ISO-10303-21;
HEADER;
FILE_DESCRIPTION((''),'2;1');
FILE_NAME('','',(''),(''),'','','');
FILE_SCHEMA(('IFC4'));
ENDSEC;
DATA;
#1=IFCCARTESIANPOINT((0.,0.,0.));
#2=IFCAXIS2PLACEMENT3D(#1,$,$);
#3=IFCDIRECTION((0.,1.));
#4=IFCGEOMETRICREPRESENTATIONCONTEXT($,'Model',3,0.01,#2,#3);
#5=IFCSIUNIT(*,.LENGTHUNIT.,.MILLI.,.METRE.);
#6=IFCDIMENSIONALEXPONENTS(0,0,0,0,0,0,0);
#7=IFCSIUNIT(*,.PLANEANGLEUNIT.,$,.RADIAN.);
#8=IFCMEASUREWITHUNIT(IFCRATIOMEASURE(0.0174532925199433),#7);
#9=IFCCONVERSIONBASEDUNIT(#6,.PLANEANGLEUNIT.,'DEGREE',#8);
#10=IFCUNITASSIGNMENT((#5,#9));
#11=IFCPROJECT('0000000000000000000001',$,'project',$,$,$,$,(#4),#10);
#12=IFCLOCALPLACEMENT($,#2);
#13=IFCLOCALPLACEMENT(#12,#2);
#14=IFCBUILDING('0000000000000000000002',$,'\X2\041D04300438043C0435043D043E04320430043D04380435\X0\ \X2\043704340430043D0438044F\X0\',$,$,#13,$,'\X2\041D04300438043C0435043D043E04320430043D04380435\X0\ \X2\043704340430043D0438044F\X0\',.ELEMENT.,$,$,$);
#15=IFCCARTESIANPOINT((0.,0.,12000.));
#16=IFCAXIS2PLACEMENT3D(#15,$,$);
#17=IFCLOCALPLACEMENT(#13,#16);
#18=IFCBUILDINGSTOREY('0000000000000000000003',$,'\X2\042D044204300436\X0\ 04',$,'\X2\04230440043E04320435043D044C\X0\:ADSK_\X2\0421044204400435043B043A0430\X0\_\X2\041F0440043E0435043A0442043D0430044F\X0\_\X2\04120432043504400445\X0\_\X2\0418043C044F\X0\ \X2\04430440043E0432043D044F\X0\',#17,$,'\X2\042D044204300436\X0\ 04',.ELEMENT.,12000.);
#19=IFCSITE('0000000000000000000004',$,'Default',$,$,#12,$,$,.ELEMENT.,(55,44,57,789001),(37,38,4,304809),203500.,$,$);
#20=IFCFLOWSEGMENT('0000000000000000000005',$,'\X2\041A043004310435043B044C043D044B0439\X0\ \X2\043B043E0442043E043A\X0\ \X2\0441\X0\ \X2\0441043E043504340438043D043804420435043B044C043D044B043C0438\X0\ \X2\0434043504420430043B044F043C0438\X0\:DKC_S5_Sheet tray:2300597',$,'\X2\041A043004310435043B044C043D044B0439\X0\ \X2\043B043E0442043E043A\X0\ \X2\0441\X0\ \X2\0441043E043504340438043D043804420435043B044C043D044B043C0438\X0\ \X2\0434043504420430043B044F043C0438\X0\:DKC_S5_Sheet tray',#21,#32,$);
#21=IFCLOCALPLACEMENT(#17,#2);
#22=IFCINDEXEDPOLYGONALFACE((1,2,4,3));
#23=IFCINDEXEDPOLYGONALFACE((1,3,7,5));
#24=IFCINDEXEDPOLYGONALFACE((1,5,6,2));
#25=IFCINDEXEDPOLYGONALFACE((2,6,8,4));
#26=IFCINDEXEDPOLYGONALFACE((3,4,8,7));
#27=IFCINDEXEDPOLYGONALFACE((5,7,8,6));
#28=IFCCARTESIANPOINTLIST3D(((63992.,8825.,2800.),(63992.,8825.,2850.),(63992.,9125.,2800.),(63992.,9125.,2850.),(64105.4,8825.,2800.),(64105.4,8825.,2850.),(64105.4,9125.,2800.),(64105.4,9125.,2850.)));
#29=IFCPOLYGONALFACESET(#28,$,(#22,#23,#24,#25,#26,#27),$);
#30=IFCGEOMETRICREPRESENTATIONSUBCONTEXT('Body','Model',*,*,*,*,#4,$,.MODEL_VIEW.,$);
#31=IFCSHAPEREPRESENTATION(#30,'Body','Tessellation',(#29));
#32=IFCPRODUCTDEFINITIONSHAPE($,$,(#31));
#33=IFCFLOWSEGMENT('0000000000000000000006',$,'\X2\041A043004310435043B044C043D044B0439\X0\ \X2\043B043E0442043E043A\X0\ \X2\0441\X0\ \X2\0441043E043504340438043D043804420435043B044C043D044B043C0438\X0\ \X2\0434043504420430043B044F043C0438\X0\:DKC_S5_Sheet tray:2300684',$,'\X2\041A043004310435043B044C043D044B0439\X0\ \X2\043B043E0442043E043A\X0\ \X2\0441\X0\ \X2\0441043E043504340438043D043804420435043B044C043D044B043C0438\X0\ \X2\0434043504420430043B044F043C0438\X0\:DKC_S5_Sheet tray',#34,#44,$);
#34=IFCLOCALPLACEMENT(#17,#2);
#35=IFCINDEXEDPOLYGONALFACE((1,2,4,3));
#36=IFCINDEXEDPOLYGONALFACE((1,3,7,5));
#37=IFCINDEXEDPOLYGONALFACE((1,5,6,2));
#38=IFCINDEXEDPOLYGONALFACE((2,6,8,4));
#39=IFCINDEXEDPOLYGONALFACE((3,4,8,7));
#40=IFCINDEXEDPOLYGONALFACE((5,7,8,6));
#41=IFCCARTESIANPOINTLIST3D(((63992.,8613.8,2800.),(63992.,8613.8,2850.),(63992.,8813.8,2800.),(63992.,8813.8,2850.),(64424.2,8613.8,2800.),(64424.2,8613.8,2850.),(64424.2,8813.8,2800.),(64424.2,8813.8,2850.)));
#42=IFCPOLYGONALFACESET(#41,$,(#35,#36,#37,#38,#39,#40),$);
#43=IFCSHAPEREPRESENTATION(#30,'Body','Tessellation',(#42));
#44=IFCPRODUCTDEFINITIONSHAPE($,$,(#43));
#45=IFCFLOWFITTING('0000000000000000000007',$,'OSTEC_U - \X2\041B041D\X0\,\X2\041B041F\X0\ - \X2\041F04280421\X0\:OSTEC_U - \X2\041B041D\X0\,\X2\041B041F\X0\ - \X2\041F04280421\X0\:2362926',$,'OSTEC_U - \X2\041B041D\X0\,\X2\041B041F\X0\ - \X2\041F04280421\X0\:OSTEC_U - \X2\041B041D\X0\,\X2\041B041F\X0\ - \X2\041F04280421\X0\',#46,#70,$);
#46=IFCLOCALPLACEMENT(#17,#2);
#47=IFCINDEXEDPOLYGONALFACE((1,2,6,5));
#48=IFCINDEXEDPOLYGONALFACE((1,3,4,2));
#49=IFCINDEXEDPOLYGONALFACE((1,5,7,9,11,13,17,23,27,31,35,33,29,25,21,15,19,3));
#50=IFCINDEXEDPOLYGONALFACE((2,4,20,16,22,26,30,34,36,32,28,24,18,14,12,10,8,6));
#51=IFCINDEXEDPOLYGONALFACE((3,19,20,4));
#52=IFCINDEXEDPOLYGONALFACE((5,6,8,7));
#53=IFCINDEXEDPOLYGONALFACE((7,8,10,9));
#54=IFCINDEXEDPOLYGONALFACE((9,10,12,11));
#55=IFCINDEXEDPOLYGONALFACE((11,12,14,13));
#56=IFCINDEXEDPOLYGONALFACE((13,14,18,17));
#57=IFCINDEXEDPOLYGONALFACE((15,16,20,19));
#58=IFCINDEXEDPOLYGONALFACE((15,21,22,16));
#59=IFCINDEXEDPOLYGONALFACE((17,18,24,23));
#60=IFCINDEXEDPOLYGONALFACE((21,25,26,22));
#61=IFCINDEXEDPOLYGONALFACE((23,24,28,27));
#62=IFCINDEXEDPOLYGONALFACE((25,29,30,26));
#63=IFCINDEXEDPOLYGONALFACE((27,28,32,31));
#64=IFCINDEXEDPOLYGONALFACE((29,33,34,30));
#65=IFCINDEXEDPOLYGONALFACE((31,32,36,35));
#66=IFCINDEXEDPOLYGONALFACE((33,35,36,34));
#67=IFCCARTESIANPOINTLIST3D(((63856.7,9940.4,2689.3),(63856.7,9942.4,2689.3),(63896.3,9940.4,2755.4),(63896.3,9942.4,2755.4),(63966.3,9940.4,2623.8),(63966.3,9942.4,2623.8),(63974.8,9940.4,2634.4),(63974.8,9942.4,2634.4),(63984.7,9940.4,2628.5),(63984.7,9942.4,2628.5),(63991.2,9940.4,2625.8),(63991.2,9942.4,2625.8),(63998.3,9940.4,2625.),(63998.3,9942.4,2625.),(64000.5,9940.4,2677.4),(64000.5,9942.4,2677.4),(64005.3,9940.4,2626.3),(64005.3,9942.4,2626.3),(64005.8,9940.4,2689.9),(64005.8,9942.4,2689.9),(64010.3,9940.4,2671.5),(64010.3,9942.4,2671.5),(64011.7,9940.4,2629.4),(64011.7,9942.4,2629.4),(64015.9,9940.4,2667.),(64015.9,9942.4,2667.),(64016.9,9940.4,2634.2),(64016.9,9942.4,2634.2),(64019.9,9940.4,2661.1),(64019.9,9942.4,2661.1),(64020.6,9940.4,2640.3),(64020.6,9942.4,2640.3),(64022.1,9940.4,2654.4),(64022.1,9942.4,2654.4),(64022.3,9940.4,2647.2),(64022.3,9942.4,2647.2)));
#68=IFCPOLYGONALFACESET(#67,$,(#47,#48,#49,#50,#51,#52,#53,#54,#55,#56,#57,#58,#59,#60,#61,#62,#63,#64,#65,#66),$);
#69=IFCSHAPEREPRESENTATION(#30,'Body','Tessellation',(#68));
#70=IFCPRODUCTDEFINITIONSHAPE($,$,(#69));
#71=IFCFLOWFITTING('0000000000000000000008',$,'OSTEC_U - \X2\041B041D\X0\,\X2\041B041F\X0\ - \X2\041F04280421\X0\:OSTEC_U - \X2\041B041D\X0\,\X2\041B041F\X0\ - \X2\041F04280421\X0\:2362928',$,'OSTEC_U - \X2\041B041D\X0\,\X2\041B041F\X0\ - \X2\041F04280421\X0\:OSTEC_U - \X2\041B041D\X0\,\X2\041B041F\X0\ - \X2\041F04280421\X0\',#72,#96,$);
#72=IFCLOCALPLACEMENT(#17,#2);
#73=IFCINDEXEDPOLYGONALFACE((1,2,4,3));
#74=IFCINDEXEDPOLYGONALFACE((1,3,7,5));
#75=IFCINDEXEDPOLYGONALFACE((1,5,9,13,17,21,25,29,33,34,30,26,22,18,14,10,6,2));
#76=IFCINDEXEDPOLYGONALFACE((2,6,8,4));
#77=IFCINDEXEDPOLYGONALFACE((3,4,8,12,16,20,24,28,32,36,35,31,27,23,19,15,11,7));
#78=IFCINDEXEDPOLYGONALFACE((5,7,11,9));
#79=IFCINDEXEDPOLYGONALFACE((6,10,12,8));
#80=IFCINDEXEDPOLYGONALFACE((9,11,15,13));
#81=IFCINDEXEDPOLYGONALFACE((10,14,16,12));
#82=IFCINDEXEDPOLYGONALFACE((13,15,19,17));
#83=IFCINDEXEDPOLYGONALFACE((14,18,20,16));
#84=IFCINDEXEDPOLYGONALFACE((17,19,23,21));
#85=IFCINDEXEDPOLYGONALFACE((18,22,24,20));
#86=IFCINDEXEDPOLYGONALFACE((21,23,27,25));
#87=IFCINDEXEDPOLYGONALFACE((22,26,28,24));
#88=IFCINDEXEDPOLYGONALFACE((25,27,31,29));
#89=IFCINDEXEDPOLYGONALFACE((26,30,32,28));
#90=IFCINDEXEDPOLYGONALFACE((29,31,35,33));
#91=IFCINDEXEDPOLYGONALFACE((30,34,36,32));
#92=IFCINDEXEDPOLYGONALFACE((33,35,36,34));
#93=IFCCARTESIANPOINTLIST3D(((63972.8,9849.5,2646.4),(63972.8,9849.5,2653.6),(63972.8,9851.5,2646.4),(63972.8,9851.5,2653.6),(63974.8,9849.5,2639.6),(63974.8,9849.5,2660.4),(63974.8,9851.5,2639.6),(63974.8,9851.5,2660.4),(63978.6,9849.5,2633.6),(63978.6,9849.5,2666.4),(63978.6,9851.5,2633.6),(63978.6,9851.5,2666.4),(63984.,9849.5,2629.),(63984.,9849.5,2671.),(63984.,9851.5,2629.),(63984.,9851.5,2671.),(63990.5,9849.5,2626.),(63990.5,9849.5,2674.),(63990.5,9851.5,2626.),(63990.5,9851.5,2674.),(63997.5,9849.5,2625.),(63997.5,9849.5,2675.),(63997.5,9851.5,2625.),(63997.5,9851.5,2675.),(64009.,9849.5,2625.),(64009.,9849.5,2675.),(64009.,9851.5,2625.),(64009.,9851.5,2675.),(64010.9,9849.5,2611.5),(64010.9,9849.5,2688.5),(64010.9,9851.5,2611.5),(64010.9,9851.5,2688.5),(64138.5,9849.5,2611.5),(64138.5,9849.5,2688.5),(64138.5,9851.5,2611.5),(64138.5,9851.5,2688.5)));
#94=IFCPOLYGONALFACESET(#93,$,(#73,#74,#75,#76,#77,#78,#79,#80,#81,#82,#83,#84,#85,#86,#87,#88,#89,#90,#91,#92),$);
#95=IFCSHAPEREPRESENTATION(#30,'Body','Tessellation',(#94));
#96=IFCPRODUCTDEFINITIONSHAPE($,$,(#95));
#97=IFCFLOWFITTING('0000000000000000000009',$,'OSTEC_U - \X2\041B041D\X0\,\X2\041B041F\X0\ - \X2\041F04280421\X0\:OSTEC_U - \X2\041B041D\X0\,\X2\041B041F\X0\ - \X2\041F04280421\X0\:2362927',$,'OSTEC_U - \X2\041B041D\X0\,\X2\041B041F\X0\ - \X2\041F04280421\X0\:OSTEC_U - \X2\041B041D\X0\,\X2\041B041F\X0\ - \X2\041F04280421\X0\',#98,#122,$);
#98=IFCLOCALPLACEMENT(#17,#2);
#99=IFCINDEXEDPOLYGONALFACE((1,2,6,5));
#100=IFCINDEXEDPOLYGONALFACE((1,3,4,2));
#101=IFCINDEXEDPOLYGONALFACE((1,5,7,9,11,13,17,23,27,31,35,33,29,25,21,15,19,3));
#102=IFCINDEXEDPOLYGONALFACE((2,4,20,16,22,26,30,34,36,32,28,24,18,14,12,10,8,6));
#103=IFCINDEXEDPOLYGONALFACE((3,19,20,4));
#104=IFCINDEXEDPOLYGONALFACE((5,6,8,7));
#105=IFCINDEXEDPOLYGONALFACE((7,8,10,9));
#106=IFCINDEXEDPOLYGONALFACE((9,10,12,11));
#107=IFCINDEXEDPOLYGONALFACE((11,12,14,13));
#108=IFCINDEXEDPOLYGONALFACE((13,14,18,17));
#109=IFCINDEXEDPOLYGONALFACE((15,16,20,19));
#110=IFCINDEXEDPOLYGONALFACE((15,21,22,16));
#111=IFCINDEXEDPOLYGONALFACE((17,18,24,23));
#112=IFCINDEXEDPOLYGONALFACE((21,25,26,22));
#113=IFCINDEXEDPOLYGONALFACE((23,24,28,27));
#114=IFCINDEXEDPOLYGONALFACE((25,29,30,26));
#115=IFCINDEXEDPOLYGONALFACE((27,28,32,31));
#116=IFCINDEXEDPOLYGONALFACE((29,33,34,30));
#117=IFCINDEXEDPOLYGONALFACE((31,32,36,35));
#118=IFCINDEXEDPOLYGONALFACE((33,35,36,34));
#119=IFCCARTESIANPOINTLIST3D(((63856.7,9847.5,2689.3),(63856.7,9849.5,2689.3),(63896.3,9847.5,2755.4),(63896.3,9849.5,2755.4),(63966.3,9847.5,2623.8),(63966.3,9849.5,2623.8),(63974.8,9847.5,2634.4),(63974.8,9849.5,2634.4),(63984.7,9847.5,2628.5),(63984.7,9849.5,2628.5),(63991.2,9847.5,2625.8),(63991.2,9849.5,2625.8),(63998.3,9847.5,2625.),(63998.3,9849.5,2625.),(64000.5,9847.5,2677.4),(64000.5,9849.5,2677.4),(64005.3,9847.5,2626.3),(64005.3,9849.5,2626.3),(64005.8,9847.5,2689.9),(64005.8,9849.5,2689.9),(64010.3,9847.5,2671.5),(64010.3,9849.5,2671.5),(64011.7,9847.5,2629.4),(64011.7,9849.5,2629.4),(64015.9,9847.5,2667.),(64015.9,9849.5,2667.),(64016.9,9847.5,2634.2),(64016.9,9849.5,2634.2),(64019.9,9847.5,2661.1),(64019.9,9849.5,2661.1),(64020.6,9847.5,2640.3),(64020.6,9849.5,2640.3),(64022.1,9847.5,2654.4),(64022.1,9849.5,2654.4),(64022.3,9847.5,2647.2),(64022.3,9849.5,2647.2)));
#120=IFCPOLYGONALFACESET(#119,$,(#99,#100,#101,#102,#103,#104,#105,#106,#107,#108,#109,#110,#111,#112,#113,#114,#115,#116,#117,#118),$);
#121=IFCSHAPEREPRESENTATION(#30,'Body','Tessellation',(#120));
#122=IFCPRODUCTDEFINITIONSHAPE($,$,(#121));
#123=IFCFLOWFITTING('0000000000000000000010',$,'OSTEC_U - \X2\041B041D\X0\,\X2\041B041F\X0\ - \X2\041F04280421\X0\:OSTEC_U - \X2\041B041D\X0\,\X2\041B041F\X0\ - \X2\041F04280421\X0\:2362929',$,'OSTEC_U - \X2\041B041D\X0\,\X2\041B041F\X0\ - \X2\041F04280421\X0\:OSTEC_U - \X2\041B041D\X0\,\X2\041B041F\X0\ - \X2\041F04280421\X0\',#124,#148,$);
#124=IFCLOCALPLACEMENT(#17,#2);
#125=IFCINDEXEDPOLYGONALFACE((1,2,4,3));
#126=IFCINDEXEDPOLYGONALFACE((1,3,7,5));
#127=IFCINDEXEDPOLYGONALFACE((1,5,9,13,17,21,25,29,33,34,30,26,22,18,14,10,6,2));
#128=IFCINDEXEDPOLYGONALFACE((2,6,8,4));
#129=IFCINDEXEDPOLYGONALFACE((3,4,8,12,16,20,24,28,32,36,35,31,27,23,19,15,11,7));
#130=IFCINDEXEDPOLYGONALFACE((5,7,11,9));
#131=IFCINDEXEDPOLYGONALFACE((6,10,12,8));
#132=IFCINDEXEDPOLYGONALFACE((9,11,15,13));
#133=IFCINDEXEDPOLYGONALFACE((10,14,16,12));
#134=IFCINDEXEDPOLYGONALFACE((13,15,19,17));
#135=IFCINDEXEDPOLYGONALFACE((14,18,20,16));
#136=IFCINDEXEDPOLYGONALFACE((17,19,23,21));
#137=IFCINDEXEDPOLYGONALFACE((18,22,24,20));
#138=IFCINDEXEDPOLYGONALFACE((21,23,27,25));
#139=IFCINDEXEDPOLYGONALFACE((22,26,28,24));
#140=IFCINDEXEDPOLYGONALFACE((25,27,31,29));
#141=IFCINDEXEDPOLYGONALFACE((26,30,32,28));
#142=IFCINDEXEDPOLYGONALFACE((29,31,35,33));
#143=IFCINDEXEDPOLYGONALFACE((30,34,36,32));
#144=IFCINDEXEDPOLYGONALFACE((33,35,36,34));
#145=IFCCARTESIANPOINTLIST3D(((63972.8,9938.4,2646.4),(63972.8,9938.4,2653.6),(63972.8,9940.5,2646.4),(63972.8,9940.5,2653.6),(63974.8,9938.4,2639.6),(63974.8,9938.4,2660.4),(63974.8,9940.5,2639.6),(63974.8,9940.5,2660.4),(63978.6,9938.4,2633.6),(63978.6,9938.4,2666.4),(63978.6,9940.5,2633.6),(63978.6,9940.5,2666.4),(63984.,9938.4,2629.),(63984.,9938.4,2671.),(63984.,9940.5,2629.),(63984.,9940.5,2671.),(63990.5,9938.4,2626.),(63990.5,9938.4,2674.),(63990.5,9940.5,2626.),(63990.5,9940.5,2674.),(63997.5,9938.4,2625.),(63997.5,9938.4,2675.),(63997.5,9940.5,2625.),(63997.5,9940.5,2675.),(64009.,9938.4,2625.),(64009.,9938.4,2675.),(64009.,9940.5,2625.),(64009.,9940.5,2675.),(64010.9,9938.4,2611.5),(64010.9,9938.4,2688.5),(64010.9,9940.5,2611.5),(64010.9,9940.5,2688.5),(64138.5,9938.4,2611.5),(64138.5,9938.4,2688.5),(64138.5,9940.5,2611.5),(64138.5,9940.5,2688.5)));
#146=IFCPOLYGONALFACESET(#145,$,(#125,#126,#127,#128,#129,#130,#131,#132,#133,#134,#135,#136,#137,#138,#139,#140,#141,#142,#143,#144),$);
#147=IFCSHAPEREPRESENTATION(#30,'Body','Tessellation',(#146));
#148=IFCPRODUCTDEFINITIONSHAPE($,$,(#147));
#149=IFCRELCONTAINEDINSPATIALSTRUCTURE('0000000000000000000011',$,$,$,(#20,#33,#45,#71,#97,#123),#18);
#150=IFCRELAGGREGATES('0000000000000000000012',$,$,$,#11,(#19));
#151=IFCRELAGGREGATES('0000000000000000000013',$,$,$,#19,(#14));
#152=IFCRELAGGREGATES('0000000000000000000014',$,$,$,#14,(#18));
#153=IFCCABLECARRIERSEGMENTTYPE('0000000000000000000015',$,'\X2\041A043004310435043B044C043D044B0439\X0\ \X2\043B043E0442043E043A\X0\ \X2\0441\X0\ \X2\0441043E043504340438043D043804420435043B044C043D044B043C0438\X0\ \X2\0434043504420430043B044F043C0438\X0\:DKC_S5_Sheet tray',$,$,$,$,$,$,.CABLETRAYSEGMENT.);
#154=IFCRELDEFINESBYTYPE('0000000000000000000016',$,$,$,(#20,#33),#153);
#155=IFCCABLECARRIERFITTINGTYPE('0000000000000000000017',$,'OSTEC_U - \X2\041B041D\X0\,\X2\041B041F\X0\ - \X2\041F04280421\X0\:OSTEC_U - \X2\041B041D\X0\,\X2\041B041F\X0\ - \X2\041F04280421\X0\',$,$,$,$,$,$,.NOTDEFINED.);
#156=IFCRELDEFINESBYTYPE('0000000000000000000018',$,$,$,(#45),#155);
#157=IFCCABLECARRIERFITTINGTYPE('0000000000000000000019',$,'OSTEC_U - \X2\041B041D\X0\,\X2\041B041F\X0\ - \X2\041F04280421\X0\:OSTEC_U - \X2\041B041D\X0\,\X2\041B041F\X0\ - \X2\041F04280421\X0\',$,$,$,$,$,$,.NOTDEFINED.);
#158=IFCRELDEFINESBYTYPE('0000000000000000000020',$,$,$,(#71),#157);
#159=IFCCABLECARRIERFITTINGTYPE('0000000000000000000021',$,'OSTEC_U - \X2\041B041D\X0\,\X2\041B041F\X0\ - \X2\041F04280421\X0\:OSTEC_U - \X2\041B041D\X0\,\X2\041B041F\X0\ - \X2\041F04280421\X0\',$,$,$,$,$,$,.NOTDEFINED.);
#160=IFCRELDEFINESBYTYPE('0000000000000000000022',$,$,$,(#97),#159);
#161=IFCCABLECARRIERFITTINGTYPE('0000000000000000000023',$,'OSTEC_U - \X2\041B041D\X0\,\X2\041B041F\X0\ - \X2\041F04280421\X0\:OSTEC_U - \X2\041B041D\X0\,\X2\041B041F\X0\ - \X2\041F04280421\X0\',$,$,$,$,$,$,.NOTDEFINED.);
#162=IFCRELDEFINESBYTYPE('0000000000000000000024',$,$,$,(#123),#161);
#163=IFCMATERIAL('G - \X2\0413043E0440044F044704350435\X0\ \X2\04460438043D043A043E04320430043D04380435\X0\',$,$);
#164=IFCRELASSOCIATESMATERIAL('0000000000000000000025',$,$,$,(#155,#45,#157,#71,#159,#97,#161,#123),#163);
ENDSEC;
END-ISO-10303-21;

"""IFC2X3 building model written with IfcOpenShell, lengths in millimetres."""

from ifc_helpers import new_model, entity, si_unit, converted_unit, direction, frame, frame_2d, origin, origin_2d_with_axis, place, context, subcontext, project, spatial, polyline, circle_curve, parameter, trimmed, segment, composite_curve, rectangle, outline, extrude, source, transform, mapped, material, type_object, type_shapes, element, save


model = new_model("IFC2X3")

# Units and contexts
model_context = context("Model", 3, precision=0.01, world=origin(), true_north=direction((0.0, 1.0)))
body_context = subcontext(model_context, "Body", "Model", "MODEL_VIEW")
ifc_project = project(units=[si_unit("LENGTHUNIT", "METRE", prefix="MILLI"), converted_unit("PLANEANGLEUNIT", "DEGREE", entity("IfcRatioMeasure", 0.0174532925199433), si_unit("PLANEANGLEUNIT", "RADIAN"), dimensions=[0, 0, 0, 0, 0, 0, 0])], contexts=[model_context])

# Site, building, storey
site_placement = place(None, origin())
site = spatial("IfcSite", under=ifc_project, at=site_placement, Name="Default", CompositionType="ELEMENT", RefLatitude=(55, 44, 57, 789001), RefLongitude=(37, 38, 4, 304809), RefElevation=203500.0)
building_placement = place(site_placement, origin())
building = spatial("IfcBuilding", under=site, at=building_placement, Name="Наименование здания", LongName="Наименование здания", CompositionType="ELEMENT")
storey_placement = place(building_placement, frame((0.0, 0.0, 12000.0)))
storey = spatial("IfcBuildingStorey", under=building, at=storey_placement, Name="Этаж 04", ObjectType="Уровень:ADSK_Стрелка_Проектная_Вверх_Имя уровня", LongName="Этаж 04", CompositionType="ELEMENT", Elevation=12000.0)

# Flow segments
cable_carrier_segment_type = type_object("IfcCableCarrierSegmentType", Name="Кабельный лоток с соединительными деталями:DKC_S5_Sheet tray", PredefinedType="CABLETRAYSEGMENT")
flow_segment_1_placement = place(storey_placement, frame((63992.0, 8825.0, 2800.0)))
element("IfcFlowSegment", 1, at=flow_segment_1_placement, inside=storey, type_object=cable_carrier_segment_type, Name="Кабельный лоток с соединительными деталями:DKC_S5_Sheet tray:2300597", ObjectType="Кабельный лоток с соединительными деталями:DKC_S5_Sheet tray", context=body_context, shape_type="SweptSolid", body=[
    extrude(rectangle(XDim=113.4, YDim=300.0, at=origin_2d_with_axis()), frame((56.7, 150.0, 0.0)), (0.0, 0.0, 1.0), 50.0),
])
flow_segment_2_placement = place(storey_placement, frame((63992.0, 8613.8, 2800.0)))
element("IfcFlowSegment", 2, at=flow_segment_2_placement, inside=storey, type_object=cable_carrier_segment_type, Name="Кабельный лоток с соединительными деталями:DKC_S5_Sheet tray:2300684", ObjectType="Кабельный лоток с соединительными деталями:DKC_S5_Sheet tray", context=body_context, shape_type="SweptSolid", body=[
    extrude(rectangle(XDim=432.2, YDim=200.0, at=origin_2d_with_axis()), frame((216.1, 100.0, 0.0)), (0.0, 0.0, 1.0), 50.0),
])

# Flow fittings
ifc_material = material(Name="G - Горячее цинкование")
cable_carrier_fitting_type_1 = type_object("IfcCableCarrierFittingType", Name="OSTEC_U - ЛН,ЛП - ПШС:OSTEC_U - ЛН,ЛП - ПШС", PredefinedType="NOTDEFINED", material=ifc_material)
shared_shape_1 = source(origin(), body_context, "Body", "SweptSolid", [
    extrude(outline(composite_curve([segment(trimmed(circle_curve(frame_2d((-41.5, 0.0), x_axis=(1.0, 0.0)), 25.0), [parameter(90.0)], [parameter(270.0)], True, "PARAMETER"), True, "CONTINUOUS"), segment(polyline([(-41.5, -25.0), (-30.0, -25.0)]), True, "CONTINUOUS"), segment(polyline([(-30.0, -25.0), (-28.1, -38.5)]), True, "CONTINUOUS"), segment(polyline([(-28.1, -38.5), (99.5, -38.5)]), True, "CONTINUOUS"), segment(polyline([(99.5, -38.5), (99.5, 38.5)]), True, "CONTINUOUS"), segment(polyline([(99.5, 38.5), (-28.1, 38.5)]), True, "CONTINUOUS"), segment(polyline([(-28.1, 38.5), (-30.0, 25.0)]), True, "CONTINUOUS"), segment(polyline([(-30.0, 25.0), (-41.5, 25.0)]), True, "CONTINUOUS")], self_intersect=False)), frame((41.5, 0.0, 0.0), z_axis=(0.0, 0.0, -1.0), x_axis=(1.0, 0.0, 0.0)), (0.0, 0.0, -1.0), 2.0),
])
type_shapes(cable_carrier_fitting_type_1, [shared_shape_1])
flow_fitting_1_placement = place(storey_placement, frame((63997.5, 9940.5, 2650.0), z_axis=(0.0, 1.0, 0.0), x_axis=(-0.858171, 0.0, 0.513364)))
element("IfcFlowFitting", 3, at=flow_fitting_1_placement, inside=storey, type_object=cable_carrier_fitting_type_1, material=ifc_material, Name="OSTEC_U - ЛН,ЛП - ПШС:OSTEC_U - ЛН,ЛП - ПШС:2362926", ObjectType="OSTEC_U - ЛН,ЛП - ПШС:OSTEC_U - ЛН,ЛП - ПШС", context=body_context, shape_type="MappedRepresentation", body=[
    mapped(shared_shape_1, transform((0.0, 0.0, 0.0), scale=1.0)),
])
cable_carrier_fitting_type_2 = type_object("IfcCableCarrierFittingType", Name="OSTEC_U - ЛН,ЛП - ПШС:OSTEC_U - ЛН,ЛП - ПШС", PredefinedType="NOTDEFINED", material=ifc_material)
type_shapes(cable_carrier_fitting_type_2, [shared_shape_1])
flow_fitting_2_placement = place(storey_placement, frame((63997.5, 9851.5, 2650.0), z_axis=(0.0, -1.0, 0.0), x_axis=(1.0, 0.0, 0.0)))
element("IfcFlowFitting", 4, at=flow_fitting_2_placement, inside=storey, type_object=cable_carrier_fitting_type_2, material=ifc_material, Name="OSTEC_U - ЛН,ЛП - ПШС:OSTEC_U - ЛН,ЛП - ПШС:2362928", ObjectType="OSTEC_U - ЛН,ЛП - ПШС:OSTEC_U - ЛН,ЛП - ПШС", context=body_context, shape_type="MappedRepresentation", body=[
    mapped(shared_shape_1, transform((0.0, 0.0, 0.0), scale=1.0)),
])
cable_carrier_fitting_type_3 = type_object("IfcCableCarrierFittingType", Name="OSTEC_U - ЛН,ЛП - ПШС:OSTEC_U - ЛН,ЛП - ПШС", PredefinedType="NOTDEFINED", material=ifc_material)
shared_shape_2 = source(origin(), body_context, "Body", "SweptSolid", [
    extrude(outline(composite_curve([segment(trimmed(circle_curve(frame_2d((-41.5, 0.0), x_axis=(1.0, 0.0)), 25.0), [parameter(90.0)], [parameter(270.0)], True, "PARAMETER"), True, "CONTINUOUS"), segment(polyline([(-41.5, -25.0), (-30.0, -25.0)]), True, "CONTINUOUS"), segment(polyline([(-30.0, -25.0), (-28.1, -38.5)]), True, "CONTINUOUS"), segment(polyline([(-28.1, -38.5), (99.5, -38.5)]), True, "CONTINUOUS"), segment(polyline([(99.5, -38.5), (99.5, 38.5)]), True, "CONTINUOUS"), segment(polyline([(99.5, 38.5), (-28.1, 38.5)]), True, "CONTINUOUS"), segment(polyline([(-28.1, 38.5), (-30.0, 25.0)]), True, "CONTINUOUS"), segment(polyline([(-30.0, 25.0), (-41.5, 25.0)]), True, "CONTINUOUS")], self_intersect=False)), frame((41.5, 0.0, 0.0)), (0.0, 0.0, 1.0), 2.0),
])
type_shapes(cable_carrier_fitting_type_3, [shared_shape_2])
flow_fitting_3_placement = place(storey_placement, frame((63997.5, 9849.5, 2650.0), z_axis=(0.0, -1.0, 0.0), x_axis=(-0.858171, 0.0, 0.513364)))
element("IfcFlowFitting", 5, at=flow_fitting_3_placement, inside=storey, type_object=cable_carrier_fitting_type_3, material=ifc_material, Name="OSTEC_U - ЛН,ЛП - ПШС:OSTEC_U - ЛН,ЛП - ПШС:2362927", ObjectType="OSTEC_U - ЛН,ЛП - ПШС:OSTEC_U - ЛН,ЛП - ПШС", context=body_context, shape_type="MappedRepresentation", body=[
    mapped(shared_shape_2, transform((0.0, 0.0, 0.0), scale=1.0)),
])
cable_carrier_fitting_type_4 = type_object("IfcCableCarrierFittingType", Name="OSTEC_U - ЛН,ЛП - ПШС:OSTEC_U - ЛН,ЛП - ПШС", PredefinedType="NOTDEFINED", material=ifc_material)
type_shapes(cable_carrier_fitting_type_4, [shared_shape_2])
flow_fitting_4_placement = place(storey_placement, frame((63997.5, 9938.5, 2650.0), z_axis=(0.0, 1.0, 0.0), x_axis=(1.0, 0.0, 0.0)))
element("IfcFlowFitting", 6, at=flow_fitting_4_placement, inside=storey, type_object=cable_carrier_fitting_type_4, material=ifc_material, Name="OSTEC_U - ЛН,ЛП - ПШС:OSTEC_U - ЛН,ЛП - ПШС:2362929", ObjectType="OSTEC_U - ЛН,ЛП - ПШС:OSTEC_U - ЛН,ЛП - ПШС", context=body_context, shape_type="MappedRepresentation", body=[
    mapped(shared_shape_2, transform((0.0, 0.0, 0.0), scale=1.0)),
])

save(model, "model.ifc")
